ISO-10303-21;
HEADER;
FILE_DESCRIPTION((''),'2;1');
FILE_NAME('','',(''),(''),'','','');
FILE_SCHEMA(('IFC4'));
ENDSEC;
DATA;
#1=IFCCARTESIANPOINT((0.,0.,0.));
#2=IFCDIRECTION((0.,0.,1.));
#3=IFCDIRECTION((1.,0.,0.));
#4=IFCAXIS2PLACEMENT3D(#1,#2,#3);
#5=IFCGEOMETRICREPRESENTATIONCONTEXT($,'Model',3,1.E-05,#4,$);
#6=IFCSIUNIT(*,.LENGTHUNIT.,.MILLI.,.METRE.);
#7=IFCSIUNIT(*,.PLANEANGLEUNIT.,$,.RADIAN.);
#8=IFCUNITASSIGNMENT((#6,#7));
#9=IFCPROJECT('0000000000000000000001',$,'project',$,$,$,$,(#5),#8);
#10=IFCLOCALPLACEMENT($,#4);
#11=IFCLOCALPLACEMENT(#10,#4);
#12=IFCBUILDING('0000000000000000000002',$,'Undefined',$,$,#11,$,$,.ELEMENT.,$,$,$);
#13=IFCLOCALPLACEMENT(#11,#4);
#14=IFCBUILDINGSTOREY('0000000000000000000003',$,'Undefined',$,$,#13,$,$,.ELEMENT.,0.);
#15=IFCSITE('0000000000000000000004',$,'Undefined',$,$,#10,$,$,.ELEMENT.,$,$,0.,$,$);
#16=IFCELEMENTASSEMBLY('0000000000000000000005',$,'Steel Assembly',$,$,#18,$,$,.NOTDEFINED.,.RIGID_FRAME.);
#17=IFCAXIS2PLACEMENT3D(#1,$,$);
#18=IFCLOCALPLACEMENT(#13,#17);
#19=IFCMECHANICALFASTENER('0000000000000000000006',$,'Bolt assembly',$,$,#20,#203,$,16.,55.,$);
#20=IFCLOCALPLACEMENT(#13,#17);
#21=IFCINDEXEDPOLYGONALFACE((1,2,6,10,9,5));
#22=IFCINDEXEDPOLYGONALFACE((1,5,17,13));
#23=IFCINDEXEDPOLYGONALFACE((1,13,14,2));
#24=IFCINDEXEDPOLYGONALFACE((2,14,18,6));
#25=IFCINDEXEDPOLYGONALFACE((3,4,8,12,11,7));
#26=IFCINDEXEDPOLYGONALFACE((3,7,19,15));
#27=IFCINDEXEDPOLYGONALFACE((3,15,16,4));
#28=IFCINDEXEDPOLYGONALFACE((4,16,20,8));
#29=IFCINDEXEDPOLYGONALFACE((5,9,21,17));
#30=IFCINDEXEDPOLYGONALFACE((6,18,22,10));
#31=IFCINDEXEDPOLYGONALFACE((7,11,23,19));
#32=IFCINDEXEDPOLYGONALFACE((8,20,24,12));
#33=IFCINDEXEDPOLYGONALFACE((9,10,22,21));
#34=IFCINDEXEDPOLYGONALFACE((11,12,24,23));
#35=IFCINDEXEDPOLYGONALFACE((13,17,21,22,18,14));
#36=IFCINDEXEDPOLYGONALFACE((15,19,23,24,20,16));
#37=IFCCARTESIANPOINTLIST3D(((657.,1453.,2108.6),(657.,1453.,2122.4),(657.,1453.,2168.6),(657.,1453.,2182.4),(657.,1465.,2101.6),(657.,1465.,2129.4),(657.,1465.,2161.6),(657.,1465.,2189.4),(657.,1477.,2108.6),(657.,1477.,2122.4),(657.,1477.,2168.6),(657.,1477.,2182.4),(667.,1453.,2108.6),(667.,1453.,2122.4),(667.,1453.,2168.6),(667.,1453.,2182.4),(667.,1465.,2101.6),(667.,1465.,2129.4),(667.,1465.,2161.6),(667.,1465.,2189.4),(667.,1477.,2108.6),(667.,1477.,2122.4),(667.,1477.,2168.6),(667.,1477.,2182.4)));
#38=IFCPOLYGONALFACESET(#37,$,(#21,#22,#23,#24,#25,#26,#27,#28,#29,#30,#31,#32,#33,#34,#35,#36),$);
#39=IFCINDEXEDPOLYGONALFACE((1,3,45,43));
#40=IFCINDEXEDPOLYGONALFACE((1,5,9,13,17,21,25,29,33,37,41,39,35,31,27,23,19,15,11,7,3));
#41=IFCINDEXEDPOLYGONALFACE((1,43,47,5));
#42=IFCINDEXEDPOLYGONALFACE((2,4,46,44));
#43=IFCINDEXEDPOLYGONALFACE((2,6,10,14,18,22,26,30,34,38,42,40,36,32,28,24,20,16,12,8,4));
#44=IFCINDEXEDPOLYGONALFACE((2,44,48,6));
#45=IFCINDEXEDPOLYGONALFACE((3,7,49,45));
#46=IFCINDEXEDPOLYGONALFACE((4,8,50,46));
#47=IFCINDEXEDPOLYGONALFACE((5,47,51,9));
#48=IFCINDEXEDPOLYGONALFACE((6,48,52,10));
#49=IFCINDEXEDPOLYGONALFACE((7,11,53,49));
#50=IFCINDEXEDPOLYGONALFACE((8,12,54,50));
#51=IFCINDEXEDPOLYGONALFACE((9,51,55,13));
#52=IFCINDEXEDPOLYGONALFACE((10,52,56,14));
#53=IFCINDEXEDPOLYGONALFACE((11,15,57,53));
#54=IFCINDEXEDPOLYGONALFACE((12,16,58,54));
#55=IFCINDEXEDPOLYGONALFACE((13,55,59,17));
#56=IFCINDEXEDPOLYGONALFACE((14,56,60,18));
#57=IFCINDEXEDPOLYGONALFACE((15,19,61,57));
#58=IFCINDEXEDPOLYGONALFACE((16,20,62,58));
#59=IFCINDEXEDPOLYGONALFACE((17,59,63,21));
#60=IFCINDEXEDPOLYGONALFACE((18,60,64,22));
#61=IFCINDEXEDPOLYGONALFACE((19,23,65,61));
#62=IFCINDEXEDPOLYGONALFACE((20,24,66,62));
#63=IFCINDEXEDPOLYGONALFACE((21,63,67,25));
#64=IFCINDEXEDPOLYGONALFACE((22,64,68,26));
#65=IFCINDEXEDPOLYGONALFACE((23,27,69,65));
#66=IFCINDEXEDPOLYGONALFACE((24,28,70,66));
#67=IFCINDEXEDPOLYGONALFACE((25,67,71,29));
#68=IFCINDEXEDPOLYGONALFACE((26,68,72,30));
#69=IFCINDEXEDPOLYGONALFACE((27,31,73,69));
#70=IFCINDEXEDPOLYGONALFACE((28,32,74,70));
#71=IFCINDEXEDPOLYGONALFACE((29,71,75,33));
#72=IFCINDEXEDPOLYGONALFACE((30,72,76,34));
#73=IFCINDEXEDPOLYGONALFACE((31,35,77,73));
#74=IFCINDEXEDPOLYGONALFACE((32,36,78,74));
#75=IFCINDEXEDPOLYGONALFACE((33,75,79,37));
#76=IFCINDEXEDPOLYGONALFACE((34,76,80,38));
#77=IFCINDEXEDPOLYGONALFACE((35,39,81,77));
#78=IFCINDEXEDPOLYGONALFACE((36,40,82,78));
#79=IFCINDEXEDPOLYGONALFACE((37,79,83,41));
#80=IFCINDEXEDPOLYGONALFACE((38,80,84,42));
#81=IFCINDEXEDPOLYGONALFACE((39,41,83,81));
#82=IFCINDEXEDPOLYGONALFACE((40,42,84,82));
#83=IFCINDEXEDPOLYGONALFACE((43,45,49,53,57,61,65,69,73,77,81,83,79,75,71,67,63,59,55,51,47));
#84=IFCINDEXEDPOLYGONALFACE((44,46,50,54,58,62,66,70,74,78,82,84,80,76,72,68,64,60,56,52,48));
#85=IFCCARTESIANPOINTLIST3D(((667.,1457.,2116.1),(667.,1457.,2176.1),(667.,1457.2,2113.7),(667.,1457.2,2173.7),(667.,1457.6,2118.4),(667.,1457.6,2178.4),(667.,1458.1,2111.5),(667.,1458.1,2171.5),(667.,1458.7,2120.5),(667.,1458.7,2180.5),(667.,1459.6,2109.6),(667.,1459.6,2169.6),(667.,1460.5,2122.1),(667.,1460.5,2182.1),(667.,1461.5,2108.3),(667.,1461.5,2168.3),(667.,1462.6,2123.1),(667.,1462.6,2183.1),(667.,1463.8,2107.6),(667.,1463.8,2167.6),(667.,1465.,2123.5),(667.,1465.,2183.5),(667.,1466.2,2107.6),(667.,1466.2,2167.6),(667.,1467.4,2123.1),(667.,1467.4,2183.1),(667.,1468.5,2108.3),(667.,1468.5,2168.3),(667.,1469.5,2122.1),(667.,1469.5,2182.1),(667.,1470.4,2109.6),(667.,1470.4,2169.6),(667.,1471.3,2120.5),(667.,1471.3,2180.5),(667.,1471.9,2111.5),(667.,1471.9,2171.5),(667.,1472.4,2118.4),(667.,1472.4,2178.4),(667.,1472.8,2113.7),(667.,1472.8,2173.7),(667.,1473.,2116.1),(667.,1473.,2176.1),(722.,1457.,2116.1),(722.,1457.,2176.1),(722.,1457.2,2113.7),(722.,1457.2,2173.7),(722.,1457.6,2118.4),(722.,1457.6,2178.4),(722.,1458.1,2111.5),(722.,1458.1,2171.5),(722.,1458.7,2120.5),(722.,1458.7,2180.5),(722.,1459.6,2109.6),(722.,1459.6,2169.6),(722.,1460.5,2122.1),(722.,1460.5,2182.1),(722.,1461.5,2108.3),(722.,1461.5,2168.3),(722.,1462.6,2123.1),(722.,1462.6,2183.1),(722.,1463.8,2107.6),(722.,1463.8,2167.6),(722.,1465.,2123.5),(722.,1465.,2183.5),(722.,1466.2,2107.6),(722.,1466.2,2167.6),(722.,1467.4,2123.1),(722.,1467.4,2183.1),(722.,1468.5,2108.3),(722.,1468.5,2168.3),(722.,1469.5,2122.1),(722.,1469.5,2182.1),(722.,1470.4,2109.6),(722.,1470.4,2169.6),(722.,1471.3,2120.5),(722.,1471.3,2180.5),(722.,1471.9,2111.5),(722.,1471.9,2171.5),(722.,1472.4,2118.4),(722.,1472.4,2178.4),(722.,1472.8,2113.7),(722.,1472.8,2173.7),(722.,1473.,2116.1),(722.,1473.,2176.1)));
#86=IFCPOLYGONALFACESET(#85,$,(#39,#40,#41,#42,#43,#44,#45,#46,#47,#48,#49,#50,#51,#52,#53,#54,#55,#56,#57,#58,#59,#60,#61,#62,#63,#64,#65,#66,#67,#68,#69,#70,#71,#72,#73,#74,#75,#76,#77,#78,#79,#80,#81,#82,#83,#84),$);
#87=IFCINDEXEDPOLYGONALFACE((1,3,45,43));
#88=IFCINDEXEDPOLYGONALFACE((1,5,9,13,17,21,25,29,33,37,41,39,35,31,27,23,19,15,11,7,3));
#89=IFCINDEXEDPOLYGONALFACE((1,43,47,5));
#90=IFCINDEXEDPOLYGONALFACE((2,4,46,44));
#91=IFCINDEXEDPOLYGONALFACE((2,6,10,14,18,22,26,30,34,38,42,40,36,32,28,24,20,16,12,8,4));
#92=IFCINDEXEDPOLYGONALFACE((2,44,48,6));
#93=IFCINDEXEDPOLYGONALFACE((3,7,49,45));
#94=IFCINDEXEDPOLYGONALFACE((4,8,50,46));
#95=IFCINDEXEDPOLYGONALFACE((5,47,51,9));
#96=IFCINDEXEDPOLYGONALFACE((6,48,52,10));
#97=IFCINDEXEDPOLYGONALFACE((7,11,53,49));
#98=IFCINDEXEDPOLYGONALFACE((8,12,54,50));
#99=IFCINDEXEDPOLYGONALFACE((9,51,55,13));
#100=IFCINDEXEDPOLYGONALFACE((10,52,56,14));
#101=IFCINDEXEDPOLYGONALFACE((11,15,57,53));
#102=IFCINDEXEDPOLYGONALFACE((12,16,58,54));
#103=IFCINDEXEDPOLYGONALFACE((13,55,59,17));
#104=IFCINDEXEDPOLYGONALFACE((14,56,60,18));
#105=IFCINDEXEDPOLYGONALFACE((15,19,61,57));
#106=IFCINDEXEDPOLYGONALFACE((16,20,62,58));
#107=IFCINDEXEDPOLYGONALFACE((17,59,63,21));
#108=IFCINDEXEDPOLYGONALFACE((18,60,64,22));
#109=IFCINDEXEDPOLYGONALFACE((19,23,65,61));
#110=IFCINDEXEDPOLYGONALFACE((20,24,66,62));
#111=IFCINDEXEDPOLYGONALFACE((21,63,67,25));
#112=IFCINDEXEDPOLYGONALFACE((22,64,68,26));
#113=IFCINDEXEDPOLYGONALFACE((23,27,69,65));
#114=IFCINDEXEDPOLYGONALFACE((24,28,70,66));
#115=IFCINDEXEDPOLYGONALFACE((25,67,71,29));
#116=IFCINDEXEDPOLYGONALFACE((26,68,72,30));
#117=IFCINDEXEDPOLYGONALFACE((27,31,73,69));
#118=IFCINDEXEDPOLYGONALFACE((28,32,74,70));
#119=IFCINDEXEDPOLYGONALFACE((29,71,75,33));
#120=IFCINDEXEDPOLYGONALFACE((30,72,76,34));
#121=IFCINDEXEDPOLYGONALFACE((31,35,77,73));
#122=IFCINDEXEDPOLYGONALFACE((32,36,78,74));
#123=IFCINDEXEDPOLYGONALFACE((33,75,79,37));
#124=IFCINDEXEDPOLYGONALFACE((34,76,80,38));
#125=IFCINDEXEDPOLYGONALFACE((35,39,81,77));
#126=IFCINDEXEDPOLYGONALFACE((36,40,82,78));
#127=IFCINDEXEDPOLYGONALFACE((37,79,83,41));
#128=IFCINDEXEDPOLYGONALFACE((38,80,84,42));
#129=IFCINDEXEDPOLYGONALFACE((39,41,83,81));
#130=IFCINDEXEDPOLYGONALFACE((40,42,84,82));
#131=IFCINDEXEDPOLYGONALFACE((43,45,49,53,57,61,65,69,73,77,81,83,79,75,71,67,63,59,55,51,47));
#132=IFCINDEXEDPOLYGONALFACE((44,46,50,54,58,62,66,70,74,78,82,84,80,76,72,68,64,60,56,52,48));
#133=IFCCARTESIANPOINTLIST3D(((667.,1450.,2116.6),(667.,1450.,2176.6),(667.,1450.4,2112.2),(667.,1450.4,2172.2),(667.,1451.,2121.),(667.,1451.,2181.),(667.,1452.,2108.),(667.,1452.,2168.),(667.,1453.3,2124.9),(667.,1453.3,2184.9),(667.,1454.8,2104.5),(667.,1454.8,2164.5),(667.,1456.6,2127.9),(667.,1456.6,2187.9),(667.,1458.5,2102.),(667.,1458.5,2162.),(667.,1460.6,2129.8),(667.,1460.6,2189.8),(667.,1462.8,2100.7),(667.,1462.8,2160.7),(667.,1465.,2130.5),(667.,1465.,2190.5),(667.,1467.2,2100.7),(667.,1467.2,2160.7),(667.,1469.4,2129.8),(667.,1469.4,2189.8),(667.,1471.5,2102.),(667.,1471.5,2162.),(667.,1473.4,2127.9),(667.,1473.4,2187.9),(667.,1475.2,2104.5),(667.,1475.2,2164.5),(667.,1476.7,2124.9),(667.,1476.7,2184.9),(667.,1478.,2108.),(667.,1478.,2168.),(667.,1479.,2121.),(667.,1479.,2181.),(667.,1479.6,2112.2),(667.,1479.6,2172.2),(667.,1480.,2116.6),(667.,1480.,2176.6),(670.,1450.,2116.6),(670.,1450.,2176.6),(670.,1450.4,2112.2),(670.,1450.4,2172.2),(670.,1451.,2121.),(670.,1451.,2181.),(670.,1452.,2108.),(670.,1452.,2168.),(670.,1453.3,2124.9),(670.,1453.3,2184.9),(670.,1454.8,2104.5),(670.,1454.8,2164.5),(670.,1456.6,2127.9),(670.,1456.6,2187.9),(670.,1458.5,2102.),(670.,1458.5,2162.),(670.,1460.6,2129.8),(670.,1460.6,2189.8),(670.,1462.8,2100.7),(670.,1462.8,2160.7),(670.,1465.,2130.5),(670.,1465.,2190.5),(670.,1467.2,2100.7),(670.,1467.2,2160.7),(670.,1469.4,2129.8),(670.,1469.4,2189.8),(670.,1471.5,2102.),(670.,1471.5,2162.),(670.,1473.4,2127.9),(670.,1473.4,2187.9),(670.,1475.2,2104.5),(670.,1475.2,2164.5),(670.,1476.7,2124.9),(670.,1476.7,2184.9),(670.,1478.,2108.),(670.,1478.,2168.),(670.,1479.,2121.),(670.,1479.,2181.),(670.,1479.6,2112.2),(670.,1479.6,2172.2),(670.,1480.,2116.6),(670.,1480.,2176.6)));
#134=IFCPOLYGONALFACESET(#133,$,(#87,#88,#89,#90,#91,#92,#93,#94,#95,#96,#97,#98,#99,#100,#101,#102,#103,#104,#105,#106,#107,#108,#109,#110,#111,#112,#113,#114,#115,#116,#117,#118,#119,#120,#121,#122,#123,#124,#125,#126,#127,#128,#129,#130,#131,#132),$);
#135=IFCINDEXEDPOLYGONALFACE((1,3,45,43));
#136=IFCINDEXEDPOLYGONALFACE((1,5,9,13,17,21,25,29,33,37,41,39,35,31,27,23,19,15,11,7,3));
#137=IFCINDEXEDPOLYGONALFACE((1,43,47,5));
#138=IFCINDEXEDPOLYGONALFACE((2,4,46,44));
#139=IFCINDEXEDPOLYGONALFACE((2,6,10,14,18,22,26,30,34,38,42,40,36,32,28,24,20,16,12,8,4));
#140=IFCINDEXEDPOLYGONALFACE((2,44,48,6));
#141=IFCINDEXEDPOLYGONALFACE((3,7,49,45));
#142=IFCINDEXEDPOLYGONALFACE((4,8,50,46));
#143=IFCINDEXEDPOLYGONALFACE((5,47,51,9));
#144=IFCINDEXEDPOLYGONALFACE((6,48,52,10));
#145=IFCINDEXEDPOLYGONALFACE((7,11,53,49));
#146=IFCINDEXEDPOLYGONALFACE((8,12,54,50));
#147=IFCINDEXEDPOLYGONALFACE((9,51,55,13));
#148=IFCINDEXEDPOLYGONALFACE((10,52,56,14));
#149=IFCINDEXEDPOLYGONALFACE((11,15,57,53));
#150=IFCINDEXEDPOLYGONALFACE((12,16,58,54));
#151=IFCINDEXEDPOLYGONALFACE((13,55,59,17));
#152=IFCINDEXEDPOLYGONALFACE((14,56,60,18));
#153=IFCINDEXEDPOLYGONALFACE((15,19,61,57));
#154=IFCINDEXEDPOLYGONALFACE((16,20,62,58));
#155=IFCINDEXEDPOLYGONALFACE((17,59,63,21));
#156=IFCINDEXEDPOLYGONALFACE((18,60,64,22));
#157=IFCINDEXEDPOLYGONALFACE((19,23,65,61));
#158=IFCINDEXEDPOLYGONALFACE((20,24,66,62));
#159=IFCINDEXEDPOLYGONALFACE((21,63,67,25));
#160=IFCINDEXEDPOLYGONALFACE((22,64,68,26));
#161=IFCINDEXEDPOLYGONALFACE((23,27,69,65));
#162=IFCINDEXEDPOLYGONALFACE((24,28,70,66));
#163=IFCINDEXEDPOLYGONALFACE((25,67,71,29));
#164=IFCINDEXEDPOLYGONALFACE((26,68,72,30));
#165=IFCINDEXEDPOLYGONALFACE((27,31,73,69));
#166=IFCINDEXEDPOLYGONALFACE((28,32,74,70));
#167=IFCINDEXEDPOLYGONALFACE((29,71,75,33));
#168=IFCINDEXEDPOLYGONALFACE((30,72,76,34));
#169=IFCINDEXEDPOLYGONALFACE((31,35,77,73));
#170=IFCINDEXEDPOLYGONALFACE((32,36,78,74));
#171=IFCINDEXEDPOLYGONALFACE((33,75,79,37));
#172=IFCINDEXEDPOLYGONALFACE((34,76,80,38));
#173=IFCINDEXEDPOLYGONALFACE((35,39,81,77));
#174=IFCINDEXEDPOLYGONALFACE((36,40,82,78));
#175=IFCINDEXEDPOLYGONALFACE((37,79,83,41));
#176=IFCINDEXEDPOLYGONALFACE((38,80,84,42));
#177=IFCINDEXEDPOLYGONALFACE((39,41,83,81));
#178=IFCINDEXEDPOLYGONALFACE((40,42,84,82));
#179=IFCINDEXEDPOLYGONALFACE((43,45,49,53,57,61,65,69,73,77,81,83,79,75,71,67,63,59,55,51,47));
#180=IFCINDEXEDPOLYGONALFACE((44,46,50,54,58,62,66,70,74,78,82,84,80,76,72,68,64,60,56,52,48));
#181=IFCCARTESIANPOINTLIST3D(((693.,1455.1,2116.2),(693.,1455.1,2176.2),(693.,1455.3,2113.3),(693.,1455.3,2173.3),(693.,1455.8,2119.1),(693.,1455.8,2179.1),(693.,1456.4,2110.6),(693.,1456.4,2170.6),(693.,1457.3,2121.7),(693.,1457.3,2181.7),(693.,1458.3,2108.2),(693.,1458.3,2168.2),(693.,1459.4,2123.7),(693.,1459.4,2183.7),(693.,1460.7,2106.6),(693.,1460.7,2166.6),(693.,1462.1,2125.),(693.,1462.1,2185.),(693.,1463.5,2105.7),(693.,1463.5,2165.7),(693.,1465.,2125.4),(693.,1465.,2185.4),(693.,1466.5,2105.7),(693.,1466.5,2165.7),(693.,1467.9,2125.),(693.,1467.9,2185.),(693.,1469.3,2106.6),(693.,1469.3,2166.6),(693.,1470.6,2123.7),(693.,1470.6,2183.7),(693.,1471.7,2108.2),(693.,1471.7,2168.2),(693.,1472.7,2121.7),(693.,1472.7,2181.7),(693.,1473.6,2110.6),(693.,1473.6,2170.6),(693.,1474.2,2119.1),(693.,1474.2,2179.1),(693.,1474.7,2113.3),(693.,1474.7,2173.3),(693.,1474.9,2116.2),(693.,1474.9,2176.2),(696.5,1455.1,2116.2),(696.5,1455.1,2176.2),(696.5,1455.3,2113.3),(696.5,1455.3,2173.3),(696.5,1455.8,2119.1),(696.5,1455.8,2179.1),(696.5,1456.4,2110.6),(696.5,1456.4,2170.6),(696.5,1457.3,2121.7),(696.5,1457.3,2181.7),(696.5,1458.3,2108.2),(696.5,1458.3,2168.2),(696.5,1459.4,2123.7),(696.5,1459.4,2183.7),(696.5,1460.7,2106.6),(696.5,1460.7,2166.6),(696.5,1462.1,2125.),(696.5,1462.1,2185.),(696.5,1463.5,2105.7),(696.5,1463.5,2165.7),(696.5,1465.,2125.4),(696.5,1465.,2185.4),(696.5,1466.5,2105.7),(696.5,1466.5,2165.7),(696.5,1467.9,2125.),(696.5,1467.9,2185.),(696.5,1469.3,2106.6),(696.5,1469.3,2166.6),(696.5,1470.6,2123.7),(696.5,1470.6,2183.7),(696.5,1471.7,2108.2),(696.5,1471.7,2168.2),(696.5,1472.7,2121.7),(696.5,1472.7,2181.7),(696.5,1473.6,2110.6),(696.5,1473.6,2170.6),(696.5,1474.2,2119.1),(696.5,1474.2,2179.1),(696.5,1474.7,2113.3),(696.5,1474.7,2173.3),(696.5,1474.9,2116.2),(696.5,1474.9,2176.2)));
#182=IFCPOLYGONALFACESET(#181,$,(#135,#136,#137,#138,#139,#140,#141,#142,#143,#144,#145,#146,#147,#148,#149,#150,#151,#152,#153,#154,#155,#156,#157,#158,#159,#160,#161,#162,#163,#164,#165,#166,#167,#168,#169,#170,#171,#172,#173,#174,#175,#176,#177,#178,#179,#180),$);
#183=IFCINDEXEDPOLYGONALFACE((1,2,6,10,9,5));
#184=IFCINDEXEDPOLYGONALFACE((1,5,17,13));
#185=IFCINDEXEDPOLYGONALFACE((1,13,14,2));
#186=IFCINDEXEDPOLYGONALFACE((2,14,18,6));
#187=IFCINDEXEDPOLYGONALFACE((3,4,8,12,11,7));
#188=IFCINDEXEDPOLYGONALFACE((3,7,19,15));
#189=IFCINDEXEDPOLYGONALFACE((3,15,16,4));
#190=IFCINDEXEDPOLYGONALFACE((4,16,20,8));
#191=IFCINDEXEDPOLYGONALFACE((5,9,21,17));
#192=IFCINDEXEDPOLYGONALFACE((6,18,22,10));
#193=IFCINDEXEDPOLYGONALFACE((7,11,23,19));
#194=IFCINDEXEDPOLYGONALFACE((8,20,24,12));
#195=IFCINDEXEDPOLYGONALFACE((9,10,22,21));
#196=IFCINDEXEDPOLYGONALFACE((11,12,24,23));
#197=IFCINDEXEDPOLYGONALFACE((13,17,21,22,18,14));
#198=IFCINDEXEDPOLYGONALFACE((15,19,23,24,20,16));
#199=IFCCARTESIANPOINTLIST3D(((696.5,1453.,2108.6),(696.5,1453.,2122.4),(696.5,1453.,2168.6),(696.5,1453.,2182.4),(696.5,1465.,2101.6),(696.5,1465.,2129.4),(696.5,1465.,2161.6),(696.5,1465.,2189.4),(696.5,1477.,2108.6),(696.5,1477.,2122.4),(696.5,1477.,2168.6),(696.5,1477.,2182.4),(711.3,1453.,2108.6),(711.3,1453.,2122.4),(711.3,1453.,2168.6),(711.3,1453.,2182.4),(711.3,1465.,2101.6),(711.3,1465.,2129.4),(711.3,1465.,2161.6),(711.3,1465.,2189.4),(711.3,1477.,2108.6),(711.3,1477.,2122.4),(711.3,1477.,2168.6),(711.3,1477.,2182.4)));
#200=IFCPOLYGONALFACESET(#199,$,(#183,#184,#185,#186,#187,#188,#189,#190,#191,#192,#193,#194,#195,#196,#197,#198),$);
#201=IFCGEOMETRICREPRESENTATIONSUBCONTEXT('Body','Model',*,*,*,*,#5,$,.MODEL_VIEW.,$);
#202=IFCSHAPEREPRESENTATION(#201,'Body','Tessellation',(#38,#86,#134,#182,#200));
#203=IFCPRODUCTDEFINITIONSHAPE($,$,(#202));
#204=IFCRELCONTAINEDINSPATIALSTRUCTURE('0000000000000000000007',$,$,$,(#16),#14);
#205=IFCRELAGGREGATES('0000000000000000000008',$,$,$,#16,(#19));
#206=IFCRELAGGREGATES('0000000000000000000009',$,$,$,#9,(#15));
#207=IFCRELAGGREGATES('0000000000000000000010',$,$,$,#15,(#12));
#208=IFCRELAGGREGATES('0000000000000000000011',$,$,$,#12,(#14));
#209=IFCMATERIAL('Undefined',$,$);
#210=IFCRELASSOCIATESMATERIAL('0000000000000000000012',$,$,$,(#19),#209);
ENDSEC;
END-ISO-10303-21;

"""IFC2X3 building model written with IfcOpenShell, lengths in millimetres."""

from ifc_helpers import new_model, si_unit, frame, origin_with_axes, origin_2d_with_axis, place, context, subcontext, project, spatial, polyline, circle, outline, extrude, source, transform, mapped, material, element, aggregate, save


model = new_model("IFC2X3")

# Units and contexts
model_context = context("Model", 3, precision=1e-05, world=origin_with_axes())
body_context = subcontext(model_context, "Body", "Model", "MODEL_VIEW")
ifc_project = project(units=[si_unit("LENGTHUNIT", "METRE", prefix="MILLI"), si_unit("PLANEANGLEUNIT", "RADIAN")], contexts=[model_context])

# Site, building, storey
site_placement = place(None, origin_with_axes())
site = spatial("IfcSite", under=ifc_project, at=site_placement, Name="Undefined", CompositionType="ELEMENT", RefElevation=0.0)
building_placement = place(site_placement, origin_with_axes())
building = spatial("IfcBuilding", under=site, at=building_placement, Name="Undefined", CompositionType="ELEMENT")
storey_placement = place(building_placement, origin_with_axes())
storey = spatial("IfcBuildingStorey", under=building, at=storey_placement, Name="Undefined", CompositionType="ELEMENT", Elevation=0.0)

# Shared definitions
ifc_material_1 = material(Name="Undefined")

# Element assembly, mechanical fastener
assembly_1_placement = place(storey_placement, origin_with_axes())
assembly_1 = element("IfcElementAssembly", 1, at=assembly_1_placement, inside=storey, Name="Steel Assembly", AssemblyPlace="NOTDEFINED", PredefinedType="RIGID_FRAME")
shared_shape_1 = source(origin_with_axes(), body_context, "Body", "SweptSolid", [
    extrude(outline(polyline([(13.9, 0.0), (6.9, 12.0), (-6.9, 12.0), (-13.9, 0.0), (-6.9, -12.0), (6.9, -12.0), (13.9, 0.0)])), frame((0.0, -30.0, 0.0), z_axis=(0.0, 1.0, 0.0), x_axis=(1.0, 0.0, 0.0)), (0.0, 0.0, 1.0), 10.0),
    extrude(circle(Radius=8.0, at=origin_2d_with_axis()), frame((0.0, -20.0, 0.0), z_axis=(0.0, 1.0, 0.0), x_axis=(1.0, 0.0, 0.0)), (0.0, 0.0, 1.0), 55.0),
    extrude(circle(Radius=15.0, at=origin_2d_with_axis()), frame((0.0, -20.0, 0.0), z_axis=(0.0, 1.0, 0.0), x_axis=(1.0, 0.0, 0.0)), (0.0, 0.0, 1.0), 3.0),
    extrude(circle(Radius=9.9, at=origin_2d_with_axis()), frame((0.0, 6.0, 0.0), z_axis=(0.0, 1.0, 0.0), x_axis=(1.0, 0.0, 0.0)), (0.0, 0.0, 1.0), 3.5),
    extrude(outline(polyline([(13.9, 0.0), (6.9, 12.0), (-6.9, 12.0), (-13.9, 0.0), (-6.9, -12.0), (6.9, -12.0), (13.9, 0.0)])), frame((0.0, 9.5, 0.0), z_axis=(0.0, 1.0, 0.0), x_axis=(1.0, 0.0, 0.0)), (0.0, 0.0, 1.0), 14.8),
])
mechanical_fastener_1_placement = place(assembly_1_placement, frame((687.0, 1465.0, 2115.5), z_axis=(0.0, 1.0, 0.0), x_axis=(0.0, 0.0, 1.0)))
mechanical_fastener_1 = element("IfcMechanicalFastener", 2, at=mechanical_fastener_1_placement, material=ifc_material_1, Name="Bolt assembly", NominalDiameter=16.0, NominalLength=55.0, context=body_context, shape_type="MappedRepresentation", body=[
    mapped(shared_shape_1, transform((0.0, 0.0, 0.0))),
    mapped(shared_shape_1, transform((60.0, 0.0, 0.0))),
])

aggregate(assembly_1, [mechanical_fastener_1])

save(model, "model.ifc")
